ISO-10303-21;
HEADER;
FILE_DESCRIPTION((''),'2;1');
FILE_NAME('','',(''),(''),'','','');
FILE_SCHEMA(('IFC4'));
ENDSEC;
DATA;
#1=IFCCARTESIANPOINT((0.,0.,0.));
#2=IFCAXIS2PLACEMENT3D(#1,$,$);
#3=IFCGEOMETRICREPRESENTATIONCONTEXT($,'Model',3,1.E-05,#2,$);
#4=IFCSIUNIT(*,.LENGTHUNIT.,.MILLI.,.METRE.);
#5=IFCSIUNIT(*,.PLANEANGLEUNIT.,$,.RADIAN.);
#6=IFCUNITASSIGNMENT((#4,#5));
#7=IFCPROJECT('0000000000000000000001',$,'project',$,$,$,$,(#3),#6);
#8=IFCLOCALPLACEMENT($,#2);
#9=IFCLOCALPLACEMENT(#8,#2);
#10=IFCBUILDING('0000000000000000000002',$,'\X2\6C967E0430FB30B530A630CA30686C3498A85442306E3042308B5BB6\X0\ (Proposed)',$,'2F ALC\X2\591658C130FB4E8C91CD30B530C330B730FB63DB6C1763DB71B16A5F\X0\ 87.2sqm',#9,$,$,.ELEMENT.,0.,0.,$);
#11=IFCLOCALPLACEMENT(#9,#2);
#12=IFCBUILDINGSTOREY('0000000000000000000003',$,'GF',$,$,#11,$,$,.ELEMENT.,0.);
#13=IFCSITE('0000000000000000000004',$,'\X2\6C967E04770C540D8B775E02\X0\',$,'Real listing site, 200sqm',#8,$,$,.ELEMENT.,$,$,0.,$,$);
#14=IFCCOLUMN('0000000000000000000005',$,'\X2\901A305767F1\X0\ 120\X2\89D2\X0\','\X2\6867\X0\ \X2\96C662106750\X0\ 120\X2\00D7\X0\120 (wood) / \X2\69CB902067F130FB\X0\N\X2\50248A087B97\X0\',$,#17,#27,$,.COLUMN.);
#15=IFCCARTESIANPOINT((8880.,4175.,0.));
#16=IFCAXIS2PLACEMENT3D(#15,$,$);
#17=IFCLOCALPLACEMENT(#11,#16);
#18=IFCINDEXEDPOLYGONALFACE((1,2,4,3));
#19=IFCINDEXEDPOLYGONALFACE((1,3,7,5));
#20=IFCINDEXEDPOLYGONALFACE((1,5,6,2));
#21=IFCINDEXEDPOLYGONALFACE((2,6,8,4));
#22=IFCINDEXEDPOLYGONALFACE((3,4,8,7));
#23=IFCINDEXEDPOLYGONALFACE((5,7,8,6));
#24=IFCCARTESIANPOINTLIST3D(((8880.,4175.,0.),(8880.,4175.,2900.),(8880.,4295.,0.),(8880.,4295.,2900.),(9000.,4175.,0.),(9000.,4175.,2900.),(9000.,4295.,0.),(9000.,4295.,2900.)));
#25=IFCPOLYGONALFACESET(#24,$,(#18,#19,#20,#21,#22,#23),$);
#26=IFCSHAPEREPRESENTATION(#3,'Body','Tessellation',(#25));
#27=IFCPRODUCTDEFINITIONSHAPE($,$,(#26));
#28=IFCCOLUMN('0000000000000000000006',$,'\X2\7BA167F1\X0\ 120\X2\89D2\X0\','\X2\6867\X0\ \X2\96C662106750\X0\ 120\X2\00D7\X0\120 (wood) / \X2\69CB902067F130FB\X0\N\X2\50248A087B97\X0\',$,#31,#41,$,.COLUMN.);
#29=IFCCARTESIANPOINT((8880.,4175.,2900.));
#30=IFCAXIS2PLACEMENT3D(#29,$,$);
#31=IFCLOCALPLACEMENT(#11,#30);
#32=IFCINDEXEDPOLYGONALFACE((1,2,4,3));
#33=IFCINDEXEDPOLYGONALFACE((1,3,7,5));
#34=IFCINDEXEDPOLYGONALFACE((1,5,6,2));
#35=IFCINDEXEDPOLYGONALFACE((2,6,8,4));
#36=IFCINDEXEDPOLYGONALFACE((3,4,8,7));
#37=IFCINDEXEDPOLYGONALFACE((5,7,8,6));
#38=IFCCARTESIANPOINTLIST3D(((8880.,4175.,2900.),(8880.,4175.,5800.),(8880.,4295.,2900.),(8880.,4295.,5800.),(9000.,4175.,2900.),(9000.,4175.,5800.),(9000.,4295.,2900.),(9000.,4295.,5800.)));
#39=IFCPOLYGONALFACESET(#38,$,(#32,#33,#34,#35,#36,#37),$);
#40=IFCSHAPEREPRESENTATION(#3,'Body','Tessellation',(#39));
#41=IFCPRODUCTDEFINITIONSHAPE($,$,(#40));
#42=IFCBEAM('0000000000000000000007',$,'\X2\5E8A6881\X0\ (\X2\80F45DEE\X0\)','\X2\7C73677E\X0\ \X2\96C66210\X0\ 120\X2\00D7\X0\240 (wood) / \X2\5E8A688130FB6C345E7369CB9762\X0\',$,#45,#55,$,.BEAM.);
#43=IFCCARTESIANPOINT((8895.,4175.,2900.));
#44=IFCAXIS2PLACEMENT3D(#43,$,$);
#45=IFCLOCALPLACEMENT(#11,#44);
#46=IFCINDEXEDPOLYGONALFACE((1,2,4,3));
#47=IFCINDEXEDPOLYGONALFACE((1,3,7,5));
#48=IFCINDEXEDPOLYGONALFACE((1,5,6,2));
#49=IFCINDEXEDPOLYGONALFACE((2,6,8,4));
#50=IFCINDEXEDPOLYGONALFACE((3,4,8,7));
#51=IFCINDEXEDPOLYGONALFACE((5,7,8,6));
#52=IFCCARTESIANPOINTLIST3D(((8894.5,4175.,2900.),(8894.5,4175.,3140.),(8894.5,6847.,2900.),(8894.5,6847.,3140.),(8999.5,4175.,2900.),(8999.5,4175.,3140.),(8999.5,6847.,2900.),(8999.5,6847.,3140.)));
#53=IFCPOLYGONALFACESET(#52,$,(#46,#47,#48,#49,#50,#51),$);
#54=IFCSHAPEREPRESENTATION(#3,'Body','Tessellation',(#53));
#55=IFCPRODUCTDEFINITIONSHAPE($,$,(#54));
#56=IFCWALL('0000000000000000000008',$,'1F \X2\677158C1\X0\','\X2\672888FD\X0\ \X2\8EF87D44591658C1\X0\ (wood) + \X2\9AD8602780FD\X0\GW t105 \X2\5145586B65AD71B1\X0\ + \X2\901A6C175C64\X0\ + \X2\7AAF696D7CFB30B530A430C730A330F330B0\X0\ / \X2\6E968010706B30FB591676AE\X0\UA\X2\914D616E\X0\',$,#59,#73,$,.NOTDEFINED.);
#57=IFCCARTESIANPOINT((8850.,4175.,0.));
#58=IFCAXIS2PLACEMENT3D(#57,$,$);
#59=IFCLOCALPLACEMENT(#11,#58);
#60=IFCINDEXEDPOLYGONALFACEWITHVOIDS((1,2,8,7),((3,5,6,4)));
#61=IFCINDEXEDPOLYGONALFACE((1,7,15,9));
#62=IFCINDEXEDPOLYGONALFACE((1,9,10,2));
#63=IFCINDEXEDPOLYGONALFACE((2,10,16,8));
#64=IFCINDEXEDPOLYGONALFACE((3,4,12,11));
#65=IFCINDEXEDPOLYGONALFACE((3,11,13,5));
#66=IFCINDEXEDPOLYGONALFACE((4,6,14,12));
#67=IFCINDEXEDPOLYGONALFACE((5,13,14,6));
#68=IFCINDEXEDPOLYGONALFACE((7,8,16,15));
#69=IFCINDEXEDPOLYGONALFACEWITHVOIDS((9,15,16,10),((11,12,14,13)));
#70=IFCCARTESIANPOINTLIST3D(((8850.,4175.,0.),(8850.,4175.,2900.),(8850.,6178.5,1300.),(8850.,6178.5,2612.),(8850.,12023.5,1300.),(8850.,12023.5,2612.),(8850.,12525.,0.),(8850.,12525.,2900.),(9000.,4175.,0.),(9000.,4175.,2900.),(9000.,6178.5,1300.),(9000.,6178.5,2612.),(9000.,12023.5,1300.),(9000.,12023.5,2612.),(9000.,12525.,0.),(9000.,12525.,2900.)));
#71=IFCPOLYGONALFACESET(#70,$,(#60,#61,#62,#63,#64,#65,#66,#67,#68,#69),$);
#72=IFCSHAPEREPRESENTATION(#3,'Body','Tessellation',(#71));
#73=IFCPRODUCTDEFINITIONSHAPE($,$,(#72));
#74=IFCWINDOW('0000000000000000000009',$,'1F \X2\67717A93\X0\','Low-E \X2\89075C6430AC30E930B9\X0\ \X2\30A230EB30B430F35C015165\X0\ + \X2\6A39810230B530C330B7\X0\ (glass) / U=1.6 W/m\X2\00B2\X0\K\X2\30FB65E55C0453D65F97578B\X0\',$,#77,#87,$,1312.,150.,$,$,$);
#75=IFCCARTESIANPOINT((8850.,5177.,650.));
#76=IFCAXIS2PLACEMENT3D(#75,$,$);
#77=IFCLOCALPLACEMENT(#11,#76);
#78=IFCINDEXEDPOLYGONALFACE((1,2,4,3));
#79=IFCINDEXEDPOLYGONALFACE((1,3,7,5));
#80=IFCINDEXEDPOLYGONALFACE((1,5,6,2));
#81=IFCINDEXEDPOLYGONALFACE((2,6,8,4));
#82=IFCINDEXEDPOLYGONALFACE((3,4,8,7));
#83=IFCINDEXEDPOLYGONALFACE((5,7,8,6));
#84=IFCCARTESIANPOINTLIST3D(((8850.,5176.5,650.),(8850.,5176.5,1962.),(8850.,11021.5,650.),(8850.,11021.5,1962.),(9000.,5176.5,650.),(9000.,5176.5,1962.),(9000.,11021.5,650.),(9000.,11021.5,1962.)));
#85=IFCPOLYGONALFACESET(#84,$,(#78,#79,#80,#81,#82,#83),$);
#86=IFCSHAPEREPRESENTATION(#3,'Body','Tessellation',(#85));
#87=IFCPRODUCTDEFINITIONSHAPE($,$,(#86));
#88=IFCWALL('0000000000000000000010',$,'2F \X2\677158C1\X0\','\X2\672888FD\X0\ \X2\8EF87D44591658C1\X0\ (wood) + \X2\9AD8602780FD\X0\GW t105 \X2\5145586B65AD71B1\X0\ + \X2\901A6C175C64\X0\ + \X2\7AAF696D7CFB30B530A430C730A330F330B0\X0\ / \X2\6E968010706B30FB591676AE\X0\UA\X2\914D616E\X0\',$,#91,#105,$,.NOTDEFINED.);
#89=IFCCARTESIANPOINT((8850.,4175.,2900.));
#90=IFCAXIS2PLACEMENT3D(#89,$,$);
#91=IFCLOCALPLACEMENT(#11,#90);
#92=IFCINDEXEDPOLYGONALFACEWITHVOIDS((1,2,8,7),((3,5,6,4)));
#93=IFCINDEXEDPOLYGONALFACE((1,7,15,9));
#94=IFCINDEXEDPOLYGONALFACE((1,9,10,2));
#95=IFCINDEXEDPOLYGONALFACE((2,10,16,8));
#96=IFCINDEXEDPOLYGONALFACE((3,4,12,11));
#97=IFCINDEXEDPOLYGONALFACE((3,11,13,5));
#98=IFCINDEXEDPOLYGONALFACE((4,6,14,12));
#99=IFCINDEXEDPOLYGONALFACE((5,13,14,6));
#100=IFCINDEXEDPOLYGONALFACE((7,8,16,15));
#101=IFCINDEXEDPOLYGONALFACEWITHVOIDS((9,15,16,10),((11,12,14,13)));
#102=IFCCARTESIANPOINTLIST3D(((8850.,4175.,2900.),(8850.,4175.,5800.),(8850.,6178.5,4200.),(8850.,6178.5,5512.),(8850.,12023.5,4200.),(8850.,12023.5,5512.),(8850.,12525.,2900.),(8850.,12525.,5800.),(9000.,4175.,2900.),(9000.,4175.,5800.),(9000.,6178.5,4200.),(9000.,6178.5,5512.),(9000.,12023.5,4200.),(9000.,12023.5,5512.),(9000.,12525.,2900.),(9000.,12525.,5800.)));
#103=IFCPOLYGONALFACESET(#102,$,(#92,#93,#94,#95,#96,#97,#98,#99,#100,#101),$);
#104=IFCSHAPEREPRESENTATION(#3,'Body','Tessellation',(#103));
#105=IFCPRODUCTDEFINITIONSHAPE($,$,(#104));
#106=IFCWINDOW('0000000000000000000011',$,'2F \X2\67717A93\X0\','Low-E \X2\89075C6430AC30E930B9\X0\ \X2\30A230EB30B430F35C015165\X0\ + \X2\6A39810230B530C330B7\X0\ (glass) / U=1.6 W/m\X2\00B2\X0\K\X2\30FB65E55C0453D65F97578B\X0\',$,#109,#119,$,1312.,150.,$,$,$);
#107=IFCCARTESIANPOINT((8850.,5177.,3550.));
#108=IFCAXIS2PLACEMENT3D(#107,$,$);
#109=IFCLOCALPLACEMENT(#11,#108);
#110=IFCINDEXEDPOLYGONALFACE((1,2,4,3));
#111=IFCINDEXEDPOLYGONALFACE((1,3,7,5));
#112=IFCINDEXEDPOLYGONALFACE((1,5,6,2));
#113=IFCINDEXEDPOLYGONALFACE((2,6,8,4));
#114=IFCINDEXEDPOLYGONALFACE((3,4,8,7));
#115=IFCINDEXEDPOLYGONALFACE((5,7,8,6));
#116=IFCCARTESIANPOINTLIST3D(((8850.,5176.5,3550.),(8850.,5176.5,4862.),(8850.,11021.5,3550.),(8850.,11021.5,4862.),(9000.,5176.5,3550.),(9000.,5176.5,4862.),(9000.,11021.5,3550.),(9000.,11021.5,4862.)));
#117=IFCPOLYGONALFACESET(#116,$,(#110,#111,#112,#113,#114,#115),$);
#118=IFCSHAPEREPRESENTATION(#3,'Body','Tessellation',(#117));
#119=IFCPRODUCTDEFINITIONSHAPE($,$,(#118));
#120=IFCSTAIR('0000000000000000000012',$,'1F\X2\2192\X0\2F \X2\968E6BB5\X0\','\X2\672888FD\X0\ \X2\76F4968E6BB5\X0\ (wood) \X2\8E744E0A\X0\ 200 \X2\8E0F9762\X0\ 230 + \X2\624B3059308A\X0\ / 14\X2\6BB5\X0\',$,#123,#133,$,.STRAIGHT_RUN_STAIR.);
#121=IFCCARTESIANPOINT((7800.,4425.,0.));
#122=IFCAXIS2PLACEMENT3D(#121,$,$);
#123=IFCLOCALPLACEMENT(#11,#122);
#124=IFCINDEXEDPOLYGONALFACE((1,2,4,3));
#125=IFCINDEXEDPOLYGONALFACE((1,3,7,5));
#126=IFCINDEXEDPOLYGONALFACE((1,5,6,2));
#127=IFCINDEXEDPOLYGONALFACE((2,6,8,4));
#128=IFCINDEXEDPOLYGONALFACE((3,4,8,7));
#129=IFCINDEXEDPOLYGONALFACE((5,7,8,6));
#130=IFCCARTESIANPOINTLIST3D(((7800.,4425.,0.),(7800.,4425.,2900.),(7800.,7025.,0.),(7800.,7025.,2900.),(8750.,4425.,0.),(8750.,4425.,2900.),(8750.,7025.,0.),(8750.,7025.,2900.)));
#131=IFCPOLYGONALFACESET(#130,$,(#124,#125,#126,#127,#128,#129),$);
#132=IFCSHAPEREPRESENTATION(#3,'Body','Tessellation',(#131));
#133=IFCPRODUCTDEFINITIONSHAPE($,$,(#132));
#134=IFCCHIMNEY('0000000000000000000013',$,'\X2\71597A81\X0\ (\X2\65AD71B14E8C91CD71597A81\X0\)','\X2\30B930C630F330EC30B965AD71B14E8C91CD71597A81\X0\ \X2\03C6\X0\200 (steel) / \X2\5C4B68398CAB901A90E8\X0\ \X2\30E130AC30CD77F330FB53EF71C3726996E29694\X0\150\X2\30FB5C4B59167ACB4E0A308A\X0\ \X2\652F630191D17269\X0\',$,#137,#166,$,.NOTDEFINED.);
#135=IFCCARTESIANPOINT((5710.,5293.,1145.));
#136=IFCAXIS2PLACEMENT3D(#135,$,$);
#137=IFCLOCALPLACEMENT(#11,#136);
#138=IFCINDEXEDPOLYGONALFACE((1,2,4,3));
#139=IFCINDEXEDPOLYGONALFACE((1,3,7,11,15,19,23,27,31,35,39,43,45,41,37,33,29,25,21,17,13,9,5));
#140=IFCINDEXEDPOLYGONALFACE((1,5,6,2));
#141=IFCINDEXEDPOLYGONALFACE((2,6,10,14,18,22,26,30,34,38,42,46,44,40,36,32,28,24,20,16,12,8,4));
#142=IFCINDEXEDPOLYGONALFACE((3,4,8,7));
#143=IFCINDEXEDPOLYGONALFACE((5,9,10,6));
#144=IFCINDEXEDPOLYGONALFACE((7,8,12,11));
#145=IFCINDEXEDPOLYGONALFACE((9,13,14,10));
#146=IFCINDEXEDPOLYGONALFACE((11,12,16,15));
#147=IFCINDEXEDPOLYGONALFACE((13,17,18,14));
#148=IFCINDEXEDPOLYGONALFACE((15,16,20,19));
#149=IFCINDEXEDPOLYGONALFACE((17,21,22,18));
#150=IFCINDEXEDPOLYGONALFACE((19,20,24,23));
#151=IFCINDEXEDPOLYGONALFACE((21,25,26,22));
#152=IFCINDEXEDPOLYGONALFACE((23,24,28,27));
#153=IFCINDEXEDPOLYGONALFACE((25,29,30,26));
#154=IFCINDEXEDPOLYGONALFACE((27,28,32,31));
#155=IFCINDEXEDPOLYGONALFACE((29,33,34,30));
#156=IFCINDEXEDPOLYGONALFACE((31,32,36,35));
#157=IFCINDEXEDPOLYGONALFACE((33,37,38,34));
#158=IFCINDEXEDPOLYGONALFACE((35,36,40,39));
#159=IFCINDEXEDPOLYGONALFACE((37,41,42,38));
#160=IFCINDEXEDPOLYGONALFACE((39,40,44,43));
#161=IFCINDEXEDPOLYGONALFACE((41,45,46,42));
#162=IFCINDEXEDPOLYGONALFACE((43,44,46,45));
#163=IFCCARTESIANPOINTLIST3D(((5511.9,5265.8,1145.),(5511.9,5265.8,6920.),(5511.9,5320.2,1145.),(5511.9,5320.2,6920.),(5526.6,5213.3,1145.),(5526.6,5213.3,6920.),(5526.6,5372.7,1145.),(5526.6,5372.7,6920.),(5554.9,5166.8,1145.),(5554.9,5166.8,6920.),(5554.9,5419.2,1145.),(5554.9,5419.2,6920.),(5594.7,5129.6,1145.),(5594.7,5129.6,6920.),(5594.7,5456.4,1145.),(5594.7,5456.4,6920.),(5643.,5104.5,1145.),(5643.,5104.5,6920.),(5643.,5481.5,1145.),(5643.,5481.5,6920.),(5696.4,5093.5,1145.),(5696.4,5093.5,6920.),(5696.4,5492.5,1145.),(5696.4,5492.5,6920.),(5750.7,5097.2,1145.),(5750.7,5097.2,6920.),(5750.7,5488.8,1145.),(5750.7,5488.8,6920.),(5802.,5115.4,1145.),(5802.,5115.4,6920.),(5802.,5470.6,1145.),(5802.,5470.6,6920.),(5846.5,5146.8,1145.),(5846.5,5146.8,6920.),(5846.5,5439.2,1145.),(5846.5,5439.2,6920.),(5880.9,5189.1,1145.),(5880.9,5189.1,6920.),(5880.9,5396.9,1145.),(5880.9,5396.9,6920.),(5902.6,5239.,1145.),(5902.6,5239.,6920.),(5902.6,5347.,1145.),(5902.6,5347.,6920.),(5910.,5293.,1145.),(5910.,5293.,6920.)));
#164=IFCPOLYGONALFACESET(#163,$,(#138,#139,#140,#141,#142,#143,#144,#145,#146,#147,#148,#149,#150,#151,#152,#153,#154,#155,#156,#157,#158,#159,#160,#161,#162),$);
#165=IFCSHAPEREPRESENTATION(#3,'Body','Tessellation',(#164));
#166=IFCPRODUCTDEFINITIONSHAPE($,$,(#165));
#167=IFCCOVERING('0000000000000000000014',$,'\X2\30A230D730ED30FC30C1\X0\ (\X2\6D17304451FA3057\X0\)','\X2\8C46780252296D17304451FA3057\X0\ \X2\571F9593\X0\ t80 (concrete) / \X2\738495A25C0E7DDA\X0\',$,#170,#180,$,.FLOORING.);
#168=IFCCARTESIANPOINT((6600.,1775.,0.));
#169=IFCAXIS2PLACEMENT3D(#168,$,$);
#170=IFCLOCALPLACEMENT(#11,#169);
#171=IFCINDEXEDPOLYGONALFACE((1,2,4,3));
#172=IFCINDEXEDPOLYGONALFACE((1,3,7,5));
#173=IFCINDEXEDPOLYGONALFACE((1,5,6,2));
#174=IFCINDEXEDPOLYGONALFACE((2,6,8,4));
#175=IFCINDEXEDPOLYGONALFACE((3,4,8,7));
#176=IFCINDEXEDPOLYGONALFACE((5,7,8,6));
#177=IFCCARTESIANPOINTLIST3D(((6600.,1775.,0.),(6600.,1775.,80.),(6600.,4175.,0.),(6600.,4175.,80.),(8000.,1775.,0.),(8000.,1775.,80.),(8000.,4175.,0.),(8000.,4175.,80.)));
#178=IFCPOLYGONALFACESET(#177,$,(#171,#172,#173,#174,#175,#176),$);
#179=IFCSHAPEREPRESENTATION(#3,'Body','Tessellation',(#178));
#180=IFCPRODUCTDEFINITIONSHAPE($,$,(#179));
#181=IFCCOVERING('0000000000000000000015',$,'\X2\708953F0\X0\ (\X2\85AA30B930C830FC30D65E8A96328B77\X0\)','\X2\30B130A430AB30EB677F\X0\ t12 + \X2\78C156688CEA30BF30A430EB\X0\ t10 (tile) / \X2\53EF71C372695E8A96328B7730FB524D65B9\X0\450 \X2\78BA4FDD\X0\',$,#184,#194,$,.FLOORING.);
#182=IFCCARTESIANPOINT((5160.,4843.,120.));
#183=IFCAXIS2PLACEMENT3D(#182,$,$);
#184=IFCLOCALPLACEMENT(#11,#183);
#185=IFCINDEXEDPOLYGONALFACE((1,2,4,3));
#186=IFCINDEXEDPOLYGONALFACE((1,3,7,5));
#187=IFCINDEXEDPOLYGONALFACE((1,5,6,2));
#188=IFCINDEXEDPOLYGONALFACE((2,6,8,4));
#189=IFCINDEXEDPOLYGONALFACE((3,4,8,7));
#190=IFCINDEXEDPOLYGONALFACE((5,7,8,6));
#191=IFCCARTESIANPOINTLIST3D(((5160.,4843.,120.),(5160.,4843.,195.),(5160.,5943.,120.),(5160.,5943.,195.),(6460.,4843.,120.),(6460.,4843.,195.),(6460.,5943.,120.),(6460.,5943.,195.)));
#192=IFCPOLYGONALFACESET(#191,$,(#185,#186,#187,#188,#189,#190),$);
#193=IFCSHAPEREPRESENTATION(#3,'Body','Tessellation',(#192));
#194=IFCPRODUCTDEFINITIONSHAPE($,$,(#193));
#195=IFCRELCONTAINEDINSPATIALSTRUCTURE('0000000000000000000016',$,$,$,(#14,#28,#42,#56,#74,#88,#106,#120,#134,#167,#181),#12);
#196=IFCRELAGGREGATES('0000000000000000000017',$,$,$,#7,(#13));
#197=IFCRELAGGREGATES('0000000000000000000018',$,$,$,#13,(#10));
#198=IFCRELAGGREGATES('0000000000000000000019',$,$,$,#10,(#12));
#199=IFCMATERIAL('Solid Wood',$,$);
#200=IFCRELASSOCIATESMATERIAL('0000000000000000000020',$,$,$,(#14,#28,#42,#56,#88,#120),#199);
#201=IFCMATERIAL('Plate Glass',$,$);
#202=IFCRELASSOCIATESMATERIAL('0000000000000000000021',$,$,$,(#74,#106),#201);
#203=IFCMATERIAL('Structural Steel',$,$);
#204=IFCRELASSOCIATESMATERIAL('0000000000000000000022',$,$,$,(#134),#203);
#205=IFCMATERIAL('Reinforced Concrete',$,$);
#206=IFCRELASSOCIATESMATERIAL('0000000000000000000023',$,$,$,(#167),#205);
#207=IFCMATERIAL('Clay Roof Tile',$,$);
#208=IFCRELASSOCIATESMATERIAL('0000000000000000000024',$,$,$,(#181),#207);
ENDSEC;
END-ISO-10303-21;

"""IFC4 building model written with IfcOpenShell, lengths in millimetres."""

from ifc_helpers import new_model, si_unit, frame, frame_2d, origin, origin_2d, place, context, project, spatial, rectangle, circle, extrude, material, element, fill, save


model = new_model("IFC4")

# Units and contexts
model_context = context("Model", 3, precision=1e-05, world=origin())
ifc_project = project(units=[si_unit("LENGTHUNIT", "METRE", prefix="MILLI"), si_unit("PLANEANGLEUNIT", "RADIAN")], contexts=[model_context])

# Site, building, storey
site_placement = place(None, origin())
site = spatial("IfcSite", under=ifc_project, at=site_placement, Name="沖縄県名護市", ObjectType="Real listing site, 200sqm", CompositionType="ELEMENT", RefElevation=0.0)
building_placement = place(site_placement, origin())
building = spatial("IfcBuilding", under=site, at=building_placement, Name="沖縄・サウナと水風呂のある家 (Proposed)", ObjectType="2F ALC外壁・二重サッシ・換気換熱機 87.2sqm", CompositionType="ELEMENT", ElevationOfRefHeight=0.0, ElevationOfTerrain=0.0)
storey_placement = place(building_placement, origin())
storey = spatial("IfcBuildingStorey", under=building, at=storey_placement, Name="GF", CompositionType="ELEMENT", Elevation=0.0)

# Columns
ifc_material_1 = material(Name="Solid Wood")
column_1_placement = place(storey_placement, frame((8880.0, 4175.0, 0.0)))
element("IfcColumn", 1, at=column_1_placement, inside=storey, material=ifc_material_1, Name="通し柱 120角", Description="桧 集成材 120×120 (wood) / 構造柱・N値計算", PredefinedType="COLUMN", context=model_context, shape_type="SweptSolid", body=[
    extrude(rectangle(XDim=120.0, YDim=120.0, at=frame_2d((60.0, 60.0))), frame((8880.0, 4175.0, 0.0)), (0.0, 0.0, 1.0), 2900.0),
])
column_2_placement = place(storey_placement, frame((8880.0, 4175.0, 2900.0)))
element("IfcColumn", 2, at=column_2_placement, inside=storey, material=ifc_material_1, Name="管柱 120角", Description="桧 集成材 120×120 (wood) / 構造柱・N値計算", PredefinedType="COLUMN", context=model_context, shape_type="SweptSolid", body=[
    extrude(rectangle(XDim=120.0, YDim=120.0, at=frame_2d((60.0, 60.0))), frame((8880.0, 4175.0, 2900.0)), (0.0, 0.0, 1.0), 2900.0),
])

# Beam
beam_1_placement = place(storey_placement, frame((8895.0, 4175.0, 2900.0)))
element("IfcBeam", 3, at=beam_1_placement, inside=storey, material=ifc_material_1, Name="床梁 (胴差)", Description="米松 集成 120×240 (wood) / 床梁・水平構面", PredefinedType="BEAM", context=model_context, shape_type="SweptSolid", body=[
    extrude(rectangle(XDim=105.0, YDim=2672.0, at=frame_2d((52.0, 1336.0))), frame((8895.0, 4175.0, 2900.0)), (0.0, 0.0, 1.0), 240.0),
])

# Wall, opening, window
wall_1_placement = place(storey_placement, frame((8850.0, 4175.0, 0.0)))
wall_1 = element("IfcWall", 4, at=wall_1_placement, inside=storey, material=ifc_material_1, Name="1F 東壁", Description="木製 軸組外壁 (wood) + 高性能GW t105 充填断熱 + 通気層 + 窯業系サイディング / 準耐火・外皮UA配慮", PredefinedType="NOTDEFINED", context=model_context, shape_type="SweptSolid", body=[
    extrude(rectangle(XDim=150.0, YDim=8350.0, at=frame_2d((75.0, 4175.0))), frame((8850.0, 4175.0, 0.0)), (0.0, 0.0, 1.0), 2900.0),
])
opening_1_placement = place(storey_placement, frame((8850.0, 5177.0, 650.0)))
opening_1 = element("IfcOpeningElement", 5, at=opening_1_placement, cuts=wall_1, PredefinedType="NOTDEFINED", context=model_context, shape_type="SweptSolid", body=[
    extrude(rectangle(XDim=150.0, YDim=5845.0, at=frame_2d((75.0, 2922.0))), frame((8850.0, 5177.0, 650.0)), (0.0, 0.0, 1.0), 1312.0),
])
ifc_material_2 = material(Name="Plate Glass")
window_1_placement = place(storey_placement, frame((8850.0, 5177.0, 650.0)))
window_1 = element("IfcWindow", 6, at=window_1_placement, inside=storey, material=ifc_material_2, Name="1F 東窓", Description="Low-E 複層ガラス アルゴン封入 + 樹脂サッシ (glass) / U=1.6 W/m²K・日射取得型", OverallHeight=1312.0, OverallWidth=150.0, context=model_context, shape_type="SweptSolid", body=[
    extrude(rectangle(XDim=150.0, YDim=5845.0, at=frame_2d((75.0, 2922.0))), frame((8850.0, 5177.0, 650.0)), (0.0, 0.0, 1.0), 1312.0),
])
fill(opening_1, window_1)

# Wall, opening, window
wall_2_placement = place(storey_placement, frame((8850.0, 4175.0, 2900.0)))
wall_2 = element("IfcWall", 7, at=wall_2_placement, inside=storey, material=ifc_material_1, Name="2F 東壁", Description="木製 軸組外壁 (wood) + 高性能GW t105 充填断熱 + 通気層 + 窯業系サイディング / 準耐火・外皮UA配慮", PredefinedType="NOTDEFINED", context=model_context, shape_type="SweptSolid", body=[
    extrude(rectangle(XDim=150.0, YDim=8350.0, at=frame_2d((75.0, 4175.0))), frame((8850.0, 4175.0, 2900.0)), (0.0, 0.0, 1.0), 2900.0),
])
opening_2_placement = place(storey_placement, frame((8850.0, 5177.0, 3550.0)))
opening_2 = element("IfcOpeningElement", 8, at=opening_2_placement, cuts=wall_2, PredefinedType="NOTDEFINED", context=model_context, shape_type="SweptSolid", body=[
    extrude(rectangle(XDim=150.0, YDim=5845.0, at=frame_2d((75.0, 2922.0))), frame((8850.0, 5177.0, 3550.0)), (0.0, 0.0, 1.0), 1312.0),
])
window_2_placement = place(storey_placement, frame((8850.0, 5177.0, 3550.0)))
window_2 = element("IfcWindow", 9, at=window_2_placement, inside=storey, material=ifc_material_2, Name="2F 東窓", Description="Low-E 複層ガラス アルゴン封入 + 樹脂サッシ (glass) / U=1.6 W/m²K・日射取得型", OverallHeight=1312.0, OverallWidth=150.0, context=model_context, shape_type="SweptSolid", body=[
    extrude(rectangle(XDim=150.0, YDim=5845.0, at=frame_2d((75.0, 2922.0))), frame((8850.0, 5177.0, 3550.0)), (0.0, 0.0, 1.0), 1312.0),
])
fill(opening_2, window_2)

# Stair
stair_placement = place(storey_placement, frame((7800.0, 4425.0, 0.0)))
element("IfcStair", 10, at=stair_placement, inside=storey, material=ifc_material_1, Name="1F→2F 階段", Description="木製 直階段 (wood) 蹴上 200 踏面 230 + 手すり / 14段", PredefinedType="STRAIGHT_RUN_STAIR", context=model_context, shape_type="SweptSolid", body=[
    extrude(rectangle(XDim=950.0, YDim=2600.0, at=frame_2d((475.0, 1300.0))), frame((7800.0, 4425.0, 0.0)), (0.0, 0.0, 1.0), 2900.0),
])

# Chimney
ifc_material_3 = material(Name="Structural Steel")
chimney_placement = place(storey_placement, frame((5710.0, 5293.0, 1145.0)))
element("IfcChimney", 11, at=chimney_placement, inside=storey, material=ifc_material_3, Name="煙突 (断熱二重煙突)", Description="ステンレス断熱二重煙突 φ200 (steel) / 屋根貫通部 メガネ石・可燃物離隔150・屋外立上り 支持金物", PredefinedType="NOTDEFINED", context=model_context, shape_type="SweptSolid", body=[
    extrude(circle(Radius=200.0, at=origin_2d()), frame((5710.0, 5293.0, 1145.0)), (0.0, 0.0, 1.0), 5775.0),
])

# Coverings
ifc_material_4 = material(Name="Reinforced Concrete")
covering_1_placement = place(storey_placement, frame((6600.0, 1775.0, 0.0)))
element("IfcCovering", 12, at=covering_1_placement, inside=storey, material=ifc_material_4, Name="アプローチ (洗い出し)", Description="豆砂利洗い出し 土間 t80 (concrete) / 玄関導線", PredefinedType="FLOORING", context=model_context, shape_type="SweptSolid", body=[
    extrude(rectangle(XDim=1400.0, YDim=2400.0, at=frame_2d((700.0, 1200.0))), frame((6600.0, 1775.0, 0.0)), (0.0, 0.0, 1.0), 80.0),
])
ifc_material_5 = material(Name="Clay Roof Tile")
covering_2_placement = place(storey_placement, frame((5160.0, 4843.0, 120.0)))
element("IfcCovering", 13, at=covering_2_placement, inside=storey, material=ifc_material_5, Name="炉台 (薪ストーブ床防護)", Description="ケイカル板 t12 + 磁器質タイル t10 (tile) / 可燃物床防護・前方450 確保", PredefinedType="FLOORING", context=model_context, shape_type="SweptSolid", body=[
    extrude(rectangle(XDim=1300.0, YDim=1100.0, at=frame_2d((650.0, 550.0))), frame((5160.0, 4843.0, 120.0)), (0.0, 0.0, 1.0), 75.0),
])

save(model, "model.ifc")
